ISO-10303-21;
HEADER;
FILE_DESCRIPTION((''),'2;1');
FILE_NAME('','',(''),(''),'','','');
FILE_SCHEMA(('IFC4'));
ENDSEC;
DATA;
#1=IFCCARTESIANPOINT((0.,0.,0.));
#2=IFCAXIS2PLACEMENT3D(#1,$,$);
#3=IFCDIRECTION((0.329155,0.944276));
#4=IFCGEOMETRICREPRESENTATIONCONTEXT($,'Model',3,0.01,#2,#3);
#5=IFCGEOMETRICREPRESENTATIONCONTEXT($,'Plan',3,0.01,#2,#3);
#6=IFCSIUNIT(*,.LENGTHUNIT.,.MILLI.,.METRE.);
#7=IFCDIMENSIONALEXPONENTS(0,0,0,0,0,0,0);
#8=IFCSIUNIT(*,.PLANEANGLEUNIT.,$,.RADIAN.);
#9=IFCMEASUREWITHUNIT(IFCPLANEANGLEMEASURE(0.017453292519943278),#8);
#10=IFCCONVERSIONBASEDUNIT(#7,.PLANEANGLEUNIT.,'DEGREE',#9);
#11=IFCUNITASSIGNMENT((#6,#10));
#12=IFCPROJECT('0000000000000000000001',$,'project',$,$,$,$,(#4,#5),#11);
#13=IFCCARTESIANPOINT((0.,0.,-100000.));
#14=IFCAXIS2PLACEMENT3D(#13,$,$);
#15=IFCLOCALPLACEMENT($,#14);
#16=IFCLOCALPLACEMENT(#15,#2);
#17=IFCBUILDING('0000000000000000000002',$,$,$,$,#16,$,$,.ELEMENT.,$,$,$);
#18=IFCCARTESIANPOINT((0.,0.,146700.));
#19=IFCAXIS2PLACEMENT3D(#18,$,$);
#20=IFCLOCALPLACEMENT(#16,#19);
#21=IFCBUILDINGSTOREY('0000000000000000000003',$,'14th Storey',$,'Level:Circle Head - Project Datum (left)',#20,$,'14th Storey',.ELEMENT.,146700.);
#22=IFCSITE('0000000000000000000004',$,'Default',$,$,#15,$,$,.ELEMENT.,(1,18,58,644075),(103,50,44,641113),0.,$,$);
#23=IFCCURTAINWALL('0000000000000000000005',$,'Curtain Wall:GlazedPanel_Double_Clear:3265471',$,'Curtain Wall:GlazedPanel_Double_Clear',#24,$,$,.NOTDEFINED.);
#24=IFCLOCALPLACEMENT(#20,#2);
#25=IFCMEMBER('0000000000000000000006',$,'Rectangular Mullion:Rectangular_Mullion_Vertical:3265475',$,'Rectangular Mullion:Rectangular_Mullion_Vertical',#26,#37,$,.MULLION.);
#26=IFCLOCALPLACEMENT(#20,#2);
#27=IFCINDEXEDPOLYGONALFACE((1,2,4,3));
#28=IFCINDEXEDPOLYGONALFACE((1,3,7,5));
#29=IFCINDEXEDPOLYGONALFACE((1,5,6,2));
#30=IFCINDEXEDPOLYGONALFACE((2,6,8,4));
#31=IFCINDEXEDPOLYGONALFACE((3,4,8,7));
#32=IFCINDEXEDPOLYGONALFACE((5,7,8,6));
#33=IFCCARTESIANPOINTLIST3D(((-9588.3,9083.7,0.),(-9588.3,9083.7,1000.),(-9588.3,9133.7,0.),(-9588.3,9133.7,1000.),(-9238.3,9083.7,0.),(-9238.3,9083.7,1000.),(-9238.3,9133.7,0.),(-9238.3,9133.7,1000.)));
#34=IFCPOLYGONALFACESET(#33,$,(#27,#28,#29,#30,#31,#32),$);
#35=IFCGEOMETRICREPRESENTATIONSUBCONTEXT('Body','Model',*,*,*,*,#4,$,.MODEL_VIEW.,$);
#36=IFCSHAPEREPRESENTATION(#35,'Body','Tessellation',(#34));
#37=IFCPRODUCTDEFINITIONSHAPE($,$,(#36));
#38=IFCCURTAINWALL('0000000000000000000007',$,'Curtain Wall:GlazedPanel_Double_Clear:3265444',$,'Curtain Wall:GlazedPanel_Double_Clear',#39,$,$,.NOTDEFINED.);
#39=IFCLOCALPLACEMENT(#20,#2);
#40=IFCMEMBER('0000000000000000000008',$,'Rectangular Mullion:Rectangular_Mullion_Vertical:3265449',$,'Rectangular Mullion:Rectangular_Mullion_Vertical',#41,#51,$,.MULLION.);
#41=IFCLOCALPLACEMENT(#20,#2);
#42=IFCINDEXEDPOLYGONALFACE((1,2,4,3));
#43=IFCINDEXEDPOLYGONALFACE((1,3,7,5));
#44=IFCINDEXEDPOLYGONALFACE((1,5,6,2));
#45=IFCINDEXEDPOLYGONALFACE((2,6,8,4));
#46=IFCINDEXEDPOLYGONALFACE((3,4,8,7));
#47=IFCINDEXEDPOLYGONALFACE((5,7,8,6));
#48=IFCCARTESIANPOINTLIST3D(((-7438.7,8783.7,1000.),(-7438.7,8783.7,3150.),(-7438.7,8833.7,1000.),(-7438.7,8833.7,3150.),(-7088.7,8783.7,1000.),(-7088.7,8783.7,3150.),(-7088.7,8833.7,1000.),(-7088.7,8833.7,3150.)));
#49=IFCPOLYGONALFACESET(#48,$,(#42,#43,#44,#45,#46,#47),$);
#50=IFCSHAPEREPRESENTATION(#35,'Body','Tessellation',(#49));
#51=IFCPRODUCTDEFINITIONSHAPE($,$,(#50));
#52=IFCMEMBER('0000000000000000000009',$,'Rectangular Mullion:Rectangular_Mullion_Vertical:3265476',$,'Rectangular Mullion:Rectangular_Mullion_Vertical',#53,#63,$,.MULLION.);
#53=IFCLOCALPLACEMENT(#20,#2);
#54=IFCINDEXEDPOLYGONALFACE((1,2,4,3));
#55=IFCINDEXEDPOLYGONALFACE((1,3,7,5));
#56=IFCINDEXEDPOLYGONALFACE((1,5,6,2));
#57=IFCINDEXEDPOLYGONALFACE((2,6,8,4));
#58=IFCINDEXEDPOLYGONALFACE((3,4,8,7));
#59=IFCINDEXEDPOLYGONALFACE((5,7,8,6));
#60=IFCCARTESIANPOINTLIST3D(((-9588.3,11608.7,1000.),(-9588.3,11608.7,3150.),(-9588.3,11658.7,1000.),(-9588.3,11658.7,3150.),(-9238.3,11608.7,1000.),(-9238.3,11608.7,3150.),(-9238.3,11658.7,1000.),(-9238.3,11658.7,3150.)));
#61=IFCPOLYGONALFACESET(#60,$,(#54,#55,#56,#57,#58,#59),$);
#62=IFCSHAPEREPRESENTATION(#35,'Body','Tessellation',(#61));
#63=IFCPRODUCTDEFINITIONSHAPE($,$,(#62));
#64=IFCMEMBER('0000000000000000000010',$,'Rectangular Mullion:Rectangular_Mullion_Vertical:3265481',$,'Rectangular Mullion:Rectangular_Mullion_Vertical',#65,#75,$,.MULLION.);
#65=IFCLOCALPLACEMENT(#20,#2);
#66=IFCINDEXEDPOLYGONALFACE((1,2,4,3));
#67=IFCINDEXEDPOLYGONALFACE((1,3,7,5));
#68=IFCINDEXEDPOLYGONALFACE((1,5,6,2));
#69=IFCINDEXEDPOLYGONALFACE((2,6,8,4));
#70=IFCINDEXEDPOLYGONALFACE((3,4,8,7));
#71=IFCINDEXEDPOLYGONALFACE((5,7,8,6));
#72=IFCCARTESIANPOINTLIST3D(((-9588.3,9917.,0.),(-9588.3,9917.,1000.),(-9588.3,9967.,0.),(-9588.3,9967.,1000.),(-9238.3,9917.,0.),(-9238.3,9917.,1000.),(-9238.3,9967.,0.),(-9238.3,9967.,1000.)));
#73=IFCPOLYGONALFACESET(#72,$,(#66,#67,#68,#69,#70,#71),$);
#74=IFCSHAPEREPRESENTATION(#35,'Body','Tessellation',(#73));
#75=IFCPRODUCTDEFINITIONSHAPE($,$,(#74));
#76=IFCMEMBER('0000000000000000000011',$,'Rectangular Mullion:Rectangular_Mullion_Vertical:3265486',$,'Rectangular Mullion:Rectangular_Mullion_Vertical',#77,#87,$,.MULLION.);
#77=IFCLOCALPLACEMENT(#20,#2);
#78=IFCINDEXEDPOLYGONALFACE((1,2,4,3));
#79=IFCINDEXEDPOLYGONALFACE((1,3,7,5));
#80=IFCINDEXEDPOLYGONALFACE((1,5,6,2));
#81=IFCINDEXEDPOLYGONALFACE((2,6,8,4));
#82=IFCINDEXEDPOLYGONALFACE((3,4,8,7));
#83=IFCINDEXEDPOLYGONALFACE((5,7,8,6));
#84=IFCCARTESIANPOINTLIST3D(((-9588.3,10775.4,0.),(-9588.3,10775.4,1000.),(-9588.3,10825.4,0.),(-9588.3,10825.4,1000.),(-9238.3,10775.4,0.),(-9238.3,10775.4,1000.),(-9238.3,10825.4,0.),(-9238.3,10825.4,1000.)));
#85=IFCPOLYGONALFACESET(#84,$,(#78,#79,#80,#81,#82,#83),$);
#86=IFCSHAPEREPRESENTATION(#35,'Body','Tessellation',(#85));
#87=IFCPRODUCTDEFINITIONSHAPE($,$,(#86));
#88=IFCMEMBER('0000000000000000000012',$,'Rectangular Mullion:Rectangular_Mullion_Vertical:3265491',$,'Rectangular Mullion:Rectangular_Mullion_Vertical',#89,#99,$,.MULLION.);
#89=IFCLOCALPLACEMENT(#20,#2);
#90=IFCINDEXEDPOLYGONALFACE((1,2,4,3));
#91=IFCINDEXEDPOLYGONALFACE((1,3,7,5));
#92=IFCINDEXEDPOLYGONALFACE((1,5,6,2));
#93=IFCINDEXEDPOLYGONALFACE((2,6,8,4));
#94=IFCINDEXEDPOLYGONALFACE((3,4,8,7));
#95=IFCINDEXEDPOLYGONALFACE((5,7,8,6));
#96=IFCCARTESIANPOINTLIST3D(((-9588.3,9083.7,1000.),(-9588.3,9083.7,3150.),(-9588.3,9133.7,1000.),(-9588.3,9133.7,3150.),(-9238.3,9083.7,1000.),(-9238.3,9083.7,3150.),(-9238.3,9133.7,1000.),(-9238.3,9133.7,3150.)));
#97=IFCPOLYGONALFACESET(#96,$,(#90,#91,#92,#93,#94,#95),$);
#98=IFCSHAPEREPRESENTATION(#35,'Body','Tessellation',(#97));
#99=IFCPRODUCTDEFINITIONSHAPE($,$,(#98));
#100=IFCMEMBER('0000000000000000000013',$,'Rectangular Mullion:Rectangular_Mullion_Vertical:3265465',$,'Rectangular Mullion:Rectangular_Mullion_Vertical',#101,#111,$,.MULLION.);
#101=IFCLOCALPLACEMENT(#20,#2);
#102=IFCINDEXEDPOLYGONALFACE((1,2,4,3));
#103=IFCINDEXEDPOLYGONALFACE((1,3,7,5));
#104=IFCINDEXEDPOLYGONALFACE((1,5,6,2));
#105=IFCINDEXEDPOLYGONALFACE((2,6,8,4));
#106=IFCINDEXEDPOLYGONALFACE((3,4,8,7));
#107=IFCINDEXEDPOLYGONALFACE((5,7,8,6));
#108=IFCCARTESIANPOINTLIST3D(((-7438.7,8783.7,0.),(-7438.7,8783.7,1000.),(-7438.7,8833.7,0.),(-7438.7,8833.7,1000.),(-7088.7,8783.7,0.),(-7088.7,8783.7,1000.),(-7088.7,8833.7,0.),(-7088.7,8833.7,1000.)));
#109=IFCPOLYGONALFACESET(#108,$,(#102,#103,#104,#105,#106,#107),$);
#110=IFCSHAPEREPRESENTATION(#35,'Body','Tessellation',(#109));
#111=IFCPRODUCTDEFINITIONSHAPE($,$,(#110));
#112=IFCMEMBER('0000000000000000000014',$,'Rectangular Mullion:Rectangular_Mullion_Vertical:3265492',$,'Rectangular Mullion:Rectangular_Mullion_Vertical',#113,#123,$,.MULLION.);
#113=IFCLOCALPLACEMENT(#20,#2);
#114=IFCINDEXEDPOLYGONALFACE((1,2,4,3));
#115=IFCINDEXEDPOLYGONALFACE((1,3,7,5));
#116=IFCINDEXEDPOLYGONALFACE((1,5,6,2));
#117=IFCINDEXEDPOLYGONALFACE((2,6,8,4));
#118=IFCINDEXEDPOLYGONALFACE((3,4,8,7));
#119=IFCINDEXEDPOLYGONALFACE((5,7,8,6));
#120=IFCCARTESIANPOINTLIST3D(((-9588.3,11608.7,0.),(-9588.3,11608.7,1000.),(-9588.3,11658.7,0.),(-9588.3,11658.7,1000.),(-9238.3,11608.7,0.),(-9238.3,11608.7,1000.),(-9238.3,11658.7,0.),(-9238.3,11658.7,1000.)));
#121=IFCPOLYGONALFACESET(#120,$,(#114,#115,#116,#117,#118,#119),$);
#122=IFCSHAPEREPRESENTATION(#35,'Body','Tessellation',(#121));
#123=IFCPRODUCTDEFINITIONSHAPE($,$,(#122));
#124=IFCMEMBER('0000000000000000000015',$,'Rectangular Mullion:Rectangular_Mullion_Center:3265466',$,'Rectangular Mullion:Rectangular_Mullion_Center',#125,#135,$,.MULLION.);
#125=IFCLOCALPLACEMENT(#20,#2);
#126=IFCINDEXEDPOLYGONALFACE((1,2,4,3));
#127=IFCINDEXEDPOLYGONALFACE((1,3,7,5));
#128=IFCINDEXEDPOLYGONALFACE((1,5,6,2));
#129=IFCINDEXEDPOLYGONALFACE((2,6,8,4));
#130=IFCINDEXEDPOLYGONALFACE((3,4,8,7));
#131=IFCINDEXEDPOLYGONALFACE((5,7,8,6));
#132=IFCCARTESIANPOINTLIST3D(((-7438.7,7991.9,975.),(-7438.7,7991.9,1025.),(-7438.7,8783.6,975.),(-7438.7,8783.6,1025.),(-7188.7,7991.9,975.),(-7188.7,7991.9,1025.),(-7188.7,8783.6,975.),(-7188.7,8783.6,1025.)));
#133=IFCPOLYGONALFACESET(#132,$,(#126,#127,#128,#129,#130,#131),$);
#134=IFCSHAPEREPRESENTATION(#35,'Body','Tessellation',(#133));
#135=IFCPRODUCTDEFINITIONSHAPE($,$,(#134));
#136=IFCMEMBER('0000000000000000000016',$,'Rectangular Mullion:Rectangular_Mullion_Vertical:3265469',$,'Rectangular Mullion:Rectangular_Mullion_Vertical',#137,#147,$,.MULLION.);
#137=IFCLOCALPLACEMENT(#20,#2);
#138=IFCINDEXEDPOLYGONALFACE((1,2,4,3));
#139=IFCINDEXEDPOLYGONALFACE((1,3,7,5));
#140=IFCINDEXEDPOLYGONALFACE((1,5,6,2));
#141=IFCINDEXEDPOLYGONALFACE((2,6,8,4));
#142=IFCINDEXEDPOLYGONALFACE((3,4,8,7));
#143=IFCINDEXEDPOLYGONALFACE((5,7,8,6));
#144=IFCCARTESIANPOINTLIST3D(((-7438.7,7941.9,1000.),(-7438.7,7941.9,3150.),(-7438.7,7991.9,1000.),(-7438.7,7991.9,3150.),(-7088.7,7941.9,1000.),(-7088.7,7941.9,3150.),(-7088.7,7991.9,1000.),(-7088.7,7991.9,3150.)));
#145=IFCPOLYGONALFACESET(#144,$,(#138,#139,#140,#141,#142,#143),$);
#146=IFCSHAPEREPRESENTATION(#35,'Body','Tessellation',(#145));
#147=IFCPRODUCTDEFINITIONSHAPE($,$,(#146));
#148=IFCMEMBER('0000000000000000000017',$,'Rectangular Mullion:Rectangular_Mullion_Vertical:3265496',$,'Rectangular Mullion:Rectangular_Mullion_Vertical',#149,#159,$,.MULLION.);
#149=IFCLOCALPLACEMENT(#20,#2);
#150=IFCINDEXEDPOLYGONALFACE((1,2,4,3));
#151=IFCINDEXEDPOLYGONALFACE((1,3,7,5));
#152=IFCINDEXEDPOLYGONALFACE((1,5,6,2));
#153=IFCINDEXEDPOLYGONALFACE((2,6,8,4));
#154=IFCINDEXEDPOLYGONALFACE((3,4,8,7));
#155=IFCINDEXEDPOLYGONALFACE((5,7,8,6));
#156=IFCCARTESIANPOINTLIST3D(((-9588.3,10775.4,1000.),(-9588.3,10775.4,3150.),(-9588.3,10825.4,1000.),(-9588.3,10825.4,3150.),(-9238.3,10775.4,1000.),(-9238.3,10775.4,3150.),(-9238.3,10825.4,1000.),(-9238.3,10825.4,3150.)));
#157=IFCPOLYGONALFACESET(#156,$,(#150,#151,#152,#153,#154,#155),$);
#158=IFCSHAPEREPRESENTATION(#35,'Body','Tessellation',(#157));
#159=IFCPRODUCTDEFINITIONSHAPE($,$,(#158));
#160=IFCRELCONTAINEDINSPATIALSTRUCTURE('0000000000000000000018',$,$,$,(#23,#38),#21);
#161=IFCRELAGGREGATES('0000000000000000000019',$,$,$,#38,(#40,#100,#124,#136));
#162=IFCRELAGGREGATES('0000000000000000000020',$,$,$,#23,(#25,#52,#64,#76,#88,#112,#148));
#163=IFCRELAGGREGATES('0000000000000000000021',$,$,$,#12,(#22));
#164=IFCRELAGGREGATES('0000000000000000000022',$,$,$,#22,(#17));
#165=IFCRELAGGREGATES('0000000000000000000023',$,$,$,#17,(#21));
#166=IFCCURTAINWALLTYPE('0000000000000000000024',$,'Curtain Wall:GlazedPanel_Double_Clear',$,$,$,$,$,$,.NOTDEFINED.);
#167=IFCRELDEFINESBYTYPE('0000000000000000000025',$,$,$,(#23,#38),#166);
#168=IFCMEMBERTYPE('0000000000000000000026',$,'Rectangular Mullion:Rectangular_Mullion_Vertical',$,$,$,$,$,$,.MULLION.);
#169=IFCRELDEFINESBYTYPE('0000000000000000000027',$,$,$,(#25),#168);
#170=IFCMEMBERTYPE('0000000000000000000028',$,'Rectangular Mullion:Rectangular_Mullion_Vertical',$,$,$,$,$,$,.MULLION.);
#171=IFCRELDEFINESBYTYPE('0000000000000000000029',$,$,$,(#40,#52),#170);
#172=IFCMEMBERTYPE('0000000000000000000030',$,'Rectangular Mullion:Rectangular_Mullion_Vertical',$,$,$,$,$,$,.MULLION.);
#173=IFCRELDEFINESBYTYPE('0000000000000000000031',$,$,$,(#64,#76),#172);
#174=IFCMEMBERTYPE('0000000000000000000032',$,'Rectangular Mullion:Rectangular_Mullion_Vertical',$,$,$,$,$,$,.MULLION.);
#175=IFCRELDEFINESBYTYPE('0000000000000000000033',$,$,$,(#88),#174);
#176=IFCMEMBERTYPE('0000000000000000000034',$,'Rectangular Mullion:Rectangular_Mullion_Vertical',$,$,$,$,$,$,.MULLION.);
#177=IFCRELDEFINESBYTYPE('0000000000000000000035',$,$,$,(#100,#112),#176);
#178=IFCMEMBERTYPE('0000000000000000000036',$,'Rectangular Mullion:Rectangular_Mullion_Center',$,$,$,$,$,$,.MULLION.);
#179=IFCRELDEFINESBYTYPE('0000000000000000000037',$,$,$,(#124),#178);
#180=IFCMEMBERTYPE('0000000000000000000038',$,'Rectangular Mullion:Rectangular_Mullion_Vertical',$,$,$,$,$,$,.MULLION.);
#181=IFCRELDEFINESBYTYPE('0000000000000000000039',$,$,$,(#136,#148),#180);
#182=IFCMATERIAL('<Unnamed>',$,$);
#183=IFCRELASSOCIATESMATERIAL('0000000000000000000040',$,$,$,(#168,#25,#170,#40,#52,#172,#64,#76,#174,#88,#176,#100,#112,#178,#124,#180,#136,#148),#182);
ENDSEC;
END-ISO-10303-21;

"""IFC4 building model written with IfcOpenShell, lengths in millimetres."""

from ifc_helpers import new_model, entity, si_unit, converted_unit, direction, frame, origin, place, context, subcontext, project, spatial, indexed_curve, outline, extrude, source, transform, mapped, material, type_object, type_shapes, element, aggregate, save


model = new_model("IFC4")

# Units and contexts
model_context = context("Model", 3, precision=0.01, world=origin(), true_north=direction((0.329155, 0.944276)))
plan_context = context("Plan", 3, precision=0.01, world=origin(), true_north=direction((0.329155, 0.944276)))
body_context = subcontext(model_context, "Body", "Model", "MODEL_VIEW")
ifc_project = project(units=[si_unit("LENGTHUNIT", "METRE", prefix="MILLI"), converted_unit("PLANEANGLEUNIT", "DEGREE", entity("IfcPlaneAngleMeasure", 0.017453292519943278), si_unit("PLANEANGLEUNIT", "RADIAN"), dimensions=[0, 0, 0, 0, 0, 0, 0])], contexts=[model_context, plan_context])

# Site, building, storey
site_placement = place(None, frame((0.0, 0.0, -100000.0)))
site = spatial("IfcSite", under=ifc_project, at=site_placement, Name="Default", CompositionType="ELEMENT", RefLatitude=(1, 18, 58, 644075), RefLongitude=(103, 50, 44, 641113), RefElevation=0.0)
building_placement = place(site_placement, origin())
building = spatial("IfcBuilding", under=site, at=building_placement, CompositionType="ELEMENT")
storey_placement = place(building_placement, frame((0.0, 0.0, 146700.0)))
storey = spatial("IfcBuildingStorey", under=building, at=storey_placement, Name="14th Storey", ObjectType="Level:Circle Head - Project Datum (left)", LongName="14th Storey", CompositionType="ELEMENT", Elevation=146700.0)

# Curtain walls, members
curtain_wall_type = type_object("IfcCurtainWallType", Name="Curtain Wall:GlazedPanel_Double_Clear", PredefinedType="NOTDEFINED")
curtain_wall_1_placement = place(storey_placement, frame((0.0, 0.0, -146700.0)))
curtain_wall_1 = element("IfcCurtainWall", 1, at=curtain_wall_1_placement, inside=storey, type_object=curtain_wall_type, Name="Curtain Wall:GlazedPanel_Double_Clear:3265471", ObjectType="Curtain Wall:GlazedPanel_Double_Clear", PredefinedType="NOTDEFINED")
ifc_material_1 = material(Name="<Unnamed>")
member_type_1 = type_object("IfcMemberType", Name="Rectangular Mullion:Rectangular_Mullion_Vertical", PredefinedType="MULLION", material=ifc_material_1)
shared_shape_1 = source(origin(), body_context, "Body", "SweptSolid", [
    extrude(outline(indexed_curve([(-25.0, -175.0), (25.0, -175.0), (25.0, 175.0), (-25.0, 175.0), (-25.0, -175.0)], self_intersect=False)), frame((-25.0, -50.0, -1000.0), z_axis=(0.0, 0.0, 1.0), x_axis=(-1.0, 0.0, 0.0)), (0.0, 0.0, 1.0), 1000.0),
])
type_shapes(member_type_1, [shared_shape_1])
member_1_placement = place(curtain_wall_1_placement, frame((-9463.3, 9083.7, 146700.0), z_axis=(0.0, 0.0, -1.0), x_axis=(0.0, -1.0, 0.0)))
member_1 = element("IfcMember", 2, at=member_1_placement, type_object=member_type_1, material=ifc_material_1, Name="Rectangular Mullion:Rectangular_Mullion_Vertical:3265475", ObjectType="Rectangular Mullion:Rectangular_Mullion_Vertical", PredefinedType="MULLION", context=body_context, shape_type="MappedRepresentation", body=[
    mapped(shared_shape_1, transform((0.0, 0.0, 0.0), scale=1.0)),
])
curtain_wall_2_placement = place(storey_placement, frame((0.0, 0.0, -146700.0)))
curtain_wall_2 = element("IfcCurtainWall", 3, at=curtain_wall_2_placement, inside=storey, type_object=curtain_wall_type, Name="Curtain Wall:GlazedPanel_Double_Clear:3265444", ObjectType="Curtain Wall:GlazedPanel_Double_Clear", PredefinedType="NOTDEFINED")
member_type_2 = type_object("IfcMemberType", Name="Rectangular Mullion:Rectangular_Mullion_Vertical", PredefinedType="MULLION", material=ifc_material_1)
shared_shape_2 = source(origin(), body_context, "Body", "SweptSolid", [
    extrude(outline(indexed_curve([(-25.0, -175.0), (25.0, -175.0), (25.0, 175.0), (-25.0, 175.0), (-25.0, -175.0)], self_intersect=False)), frame((-25.0, -50.0, -2150.0), z_axis=(0.0, 0.0, 1.0), x_axis=(-1.0, 0.0, 0.0)), (0.0, 0.0, 1.0), 2150.0),
])
type_shapes(member_type_2, [shared_shape_2])
member_2_placement = place(curtain_wall_2_placement, frame((-7313.7, 8833.7, 149850.0), z_axis=(0.0, 0.0, 1.0), x_axis=(0.0, 1.0, 0.0)))
member_2 = element("IfcMember", 4, at=member_2_placement, type_object=member_type_2, material=ifc_material_1, Name="Rectangular Mullion:Rectangular_Mullion_Vertical:3265449", ObjectType="Rectangular Mullion:Rectangular_Mullion_Vertical", PredefinedType="MULLION", context=body_context, shape_type="MappedRepresentation", body=[
    mapped(shared_shape_2, transform((0.0, 0.0, 0.0), scale=1.0)),
])

# Members
member_3_placement = place(curtain_wall_1_placement, frame((-9463.3, 11658.7, 149850.0), z_axis=(0.0, 0.0, 1.0), x_axis=(0.0, 1.0, 0.0)))
member_3 = element("IfcMember", 5, at=member_3_placement, type_object=member_type_2, material=ifc_material_1, Name="Rectangular Mullion:Rectangular_Mullion_Vertical:3265476", ObjectType="Rectangular Mullion:Rectangular_Mullion_Vertical", PredefinedType="MULLION", context=body_context, shape_type="MappedRepresentation", body=[
    mapped(shared_shape_2, transform((0.0, 0.0, 0.0), scale=1.0)),
])
member_type_3 = type_object("IfcMemberType", Name="Rectangular Mullion:Rectangular_Mullion_Vertical", PredefinedType="MULLION", material=ifc_material_1)
shared_shape_3 = source(origin(), body_context, "Body", "SweptSolid", [
    extrude(outline(indexed_curve([(-25.0, -175.0), (25.0, -175.0), (25.0, 175.0), (-25.0, 175.0), (-25.0, -175.0)], self_intersect=False)), frame((0.0, -50.0, -1000.0), z_axis=(0.0, 0.0, 1.0), x_axis=(-1.0, 0.0, 0.0)), (0.0, 0.0, 1.0), 1000.0),
])
type_shapes(member_type_3, [shared_shape_3])
member_4_placement = place(curtain_wall_1_placement, frame((-9463.3, 9942.0, 146700.0), z_axis=(0.0, 0.0, -1.0), x_axis=(0.0, -1.0, 0.0)))
member_4 = element("IfcMember", 6, at=member_4_placement, type_object=member_type_3, material=ifc_material_1, Name="Rectangular Mullion:Rectangular_Mullion_Vertical:3265481", ObjectType="Rectangular Mullion:Rectangular_Mullion_Vertical", PredefinedType="MULLION", context=body_context, shape_type="MappedRepresentation", body=[
    mapped(shared_shape_3, transform((0.0, 0.0, 0.0), scale=1.0)),
])
member_5_placement = place(curtain_wall_1_placement, frame((-9463.3, 10800.4, 146700.0), z_axis=(0.0, 0.0, -1.0), x_axis=(0.0, -1.0, 0.0)))
member_5 = element("IfcMember", 7, at=member_5_placement, type_object=member_type_3, material=ifc_material_1, Name="Rectangular Mullion:Rectangular_Mullion_Vertical:3265486", ObjectType="Rectangular Mullion:Rectangular_Mullion_Vertical", PredefinedType="MULLION", context=body_context, shape_type="MappedRepresentation", body=[
    mapped(shared_shape_3, transform((0.0, 0.0, 0.0), scale=1.0)),
])
member_type_4 = type_object("IfcMemberType", Name="Rectangular Mullion:Rectangular_Mullion_Vertical", PredefinedType="MULLION", material=ifc_material_1)
shared_shape_4 = source(origin(), body_context, "Body", "SweptSolid", [
    extrude(outline(indexed_curve([(-25.0, -175.0), (25.0, -175.0), (25.0, 175.0), (-25.0, 175.0), (-25.0, -175.0)], self_intersect=False)), frame((-25.0, -50.0, -2150.0), z_axis=(0.0, 0.0, 1.0), x_axis=(-1.0, 0.0, 0.0)), (0.0, 0.0, 1.0), 2150.0),
])
type_shapes(member_type_4, [shared_shape_4])
member_6_placement = place(curtain_wall_1_placement, frame((-9463.3, 9083.7, 147700.0), z_axis=(0.0, 0.0, -1.0), x_axis=(0.0, -1.0, 0.0)))
member_6 = element("IfcMember", 8, at=member_6_placement, type_object=member_type_4, material=ifc_material_1, Name="Rectangular Mullion:Rectangular_Mullion_Vertical:3265491", ObjectType="Rectangular Mullion:Rectangular_Mullion_Vertical", PredefinedType="MULLION", context=body_context, shape_type="MappedRepresentation", body=[
    mapped(shared_shape_4, transform((0.0, 0.0, 0.0), scale=1.0)),
])
member_type_5 = type_object("IfcMemberType", Name="Rectangular Mullion:Rectangular_Mullion_Vertical", PredefinedType="MULLION", material=ifc_material_1)
shared_shape_5 = source(origin(), body_context, "Body", "SweptSolid", [
    extrude(outline(indexed_curve([(-25.0, -175.0), (25.0, -175.0), (25.0, 175.0), (-25.0, 175.0), (-25.0, -175.0)], self_intersect=False)), frame((-25.0, -50.0, -1000.0), z_axis=(0.0, 0.0, 1.0), x_axis=(-1.0, 0.0, 0.0)), (0.0, 0.0, 1.0), 1000.0),
])
type_shapes(member_type_5, [shared_shape_5])
member_7_placement = place(curtain_wall_2_placement, frame((-7313.7, 8833.7, 147700.0), z_axis=(0.0, 0.0, 1.0), x_axis=(0.0, 1.0, 0.0)))
member_7 = element("IfcMember", 9, at=member_7_placement, type_object=member_type_5, material=ifc_material_1, Name="Rectangular Mullion:Rectangular_Mullion_Vertical:3265465", ObjectType="Rectangular Mullion:Rectangular_Mullion_Vertical", PredefinedType="MULLION", context=body_context, shape_type="MappedRepresentation", body=[
    mapped(shared_shape_5, transform((0.0, 0.0, 0.0), scale=1.0)),
])
member_8_placement = place(curtain_wall_1_placement, frame((-9463.3, 11658.7, 147700.0), z_axis=(0.0, 0.0, 1.0), x_axis=(0.0, 1.0, 0.0)))
member_8 = element("IfcMember", 10, at=member_8_placement, type_object=member_type_5, material=ifc_material_1, Name="Rectangular Mullion:Rectangular_Mullion_Vertical:3265492", ObjectType="Rectangular Mullion:Rectangular_Mullion_Vertical", PredefinedType="MULLION", context=body_context, shape_type="MappedRepresentation", body=[
    mapped(shared_shape_5, transform((0.0, 0.0, 0.0), scale=1.0)),
])
member_type_6 = type_object("IfcMemberType", Name="Rectangular Mullion:Rectangular_Mullion_Center", PredefinedType="MULLION", material=ifc_material_1)
shared_shape_6 = source(origin(), body_context, "Body", "SweptSolid", [
    extrude(outline(indexed_curve([(-25.0, -125.0), (25.0, -125.0), (25.0, 125.0), (-25.0, 125.0), (-25.0, -125.0)], self_intersect=False)), frame((0.0, 0.0, -791.7), z_axis=(0.0, 0.0, 1.0), x_axis=(-1.0, 0.0, 0.0)), (0.0, 0.0, 1.0), 791.7),
])
type_shapes(member_type_6, [shared_shape_6])
member_9_placement = place(curtain_wall_2_placement, frame((-7313.7, 7991.9, 147700.0), z_axis=(0.0, -1.0, 0.0), x_axis=(0.0, 0.0, 1.0)))
member_9 = element("IfcMember", 11, at=member_9_placement, type_object=member_type_6, material=ifc_material_1, Name="Rectangular Mullion:Rectangular_Mullion_Center:3265466", ObjectType="Rectangular Mullion:Rectangular_Mullion_Center", PredefinedType="MULLION", context=body_context, shape_type="MappedRepresentation", body=[
    mapped(shared_shape_6, transform((0.0, 0.0, 0.0), scale=1.0)),
])
member_type_7 = type_object("IfcMemberType", Name="Rectangular Mullion:Rectangular_Mullion_Vertical", PredefinedType="MULLION", material=ifc_material_1)
shared_shape_7 = source(origin(), body_context, "Body", "SweptSolid", [
    extrude(outline(indexed_curve([(-25.0, -175.0), (25.0, -175.0), (25.0, 175.0), (-25.0, 175.0), (-25.0, -175.0)], self_intersect=False)), frame((0.0, -50.0, -2150.0), z_axis=(0.0, 0.0, 1.0), x_axis=(-1.0, 0.0, 0.0)), (0.0, 0.0, 1.0), 2150.0),
])
type_shapes(member_type_7, [shared_shape_7])
member_10_placement = place(curtain_wall_2_placement, frame((-7313.7, 7966.9, 147700.0), z_axis=(0.0, 0.0, -1.0), x_axis=(0.0, -1.0, 0.0)))
member_10 = element("IfcMember", 12, at=member_10_placement, type_object=member_type_7, material=ifc_material_1, Name="Rectangular Mullion:Rectangular_Mullion_Vertical:3265469", ObjectType="Rectangular Mullion:Rectangular_Mullion_Vertical", PredefinedType="MULLION", context=body_context, shape_type="MappedRepresentation", body=[
    mapped(shared_shape_7, transform((0.0, 0.0, 0.0), scale=1.0)),
])
member_11_placement = place(curtain_wall_1_placement, frame((-9463.3, 10800.4, 147700.0), z_axis=(0.0, 0.0, -1.0), x_axis=(0.0, -1.0, 0.0)))
member_11 = element("IfcMember", 13, at=member_11_placement, type_object=member_type_7, material=ifc_material_1, Name="Rectangular Mullion:Rectangular_Mullion_Vertical:3265496", ObjectType="Rectangular Mullion:Rectangular_Mullion_Vertical", PredefinedType="MULLION", context=body_context, shape_type="MappedRepresentation", body=[
    mapped(shared_shape_7, transform((0.0, 0.0, 0.0), scale=1.0)),
])

aggregate(curtain_wall_2, [member_2, member_7, member_9, member_10])
aggregate(curtain_wall_1, [member_1, member_3, member_4, member_5, member_6, member_8, member_11])

save(model, "model.ifc")
